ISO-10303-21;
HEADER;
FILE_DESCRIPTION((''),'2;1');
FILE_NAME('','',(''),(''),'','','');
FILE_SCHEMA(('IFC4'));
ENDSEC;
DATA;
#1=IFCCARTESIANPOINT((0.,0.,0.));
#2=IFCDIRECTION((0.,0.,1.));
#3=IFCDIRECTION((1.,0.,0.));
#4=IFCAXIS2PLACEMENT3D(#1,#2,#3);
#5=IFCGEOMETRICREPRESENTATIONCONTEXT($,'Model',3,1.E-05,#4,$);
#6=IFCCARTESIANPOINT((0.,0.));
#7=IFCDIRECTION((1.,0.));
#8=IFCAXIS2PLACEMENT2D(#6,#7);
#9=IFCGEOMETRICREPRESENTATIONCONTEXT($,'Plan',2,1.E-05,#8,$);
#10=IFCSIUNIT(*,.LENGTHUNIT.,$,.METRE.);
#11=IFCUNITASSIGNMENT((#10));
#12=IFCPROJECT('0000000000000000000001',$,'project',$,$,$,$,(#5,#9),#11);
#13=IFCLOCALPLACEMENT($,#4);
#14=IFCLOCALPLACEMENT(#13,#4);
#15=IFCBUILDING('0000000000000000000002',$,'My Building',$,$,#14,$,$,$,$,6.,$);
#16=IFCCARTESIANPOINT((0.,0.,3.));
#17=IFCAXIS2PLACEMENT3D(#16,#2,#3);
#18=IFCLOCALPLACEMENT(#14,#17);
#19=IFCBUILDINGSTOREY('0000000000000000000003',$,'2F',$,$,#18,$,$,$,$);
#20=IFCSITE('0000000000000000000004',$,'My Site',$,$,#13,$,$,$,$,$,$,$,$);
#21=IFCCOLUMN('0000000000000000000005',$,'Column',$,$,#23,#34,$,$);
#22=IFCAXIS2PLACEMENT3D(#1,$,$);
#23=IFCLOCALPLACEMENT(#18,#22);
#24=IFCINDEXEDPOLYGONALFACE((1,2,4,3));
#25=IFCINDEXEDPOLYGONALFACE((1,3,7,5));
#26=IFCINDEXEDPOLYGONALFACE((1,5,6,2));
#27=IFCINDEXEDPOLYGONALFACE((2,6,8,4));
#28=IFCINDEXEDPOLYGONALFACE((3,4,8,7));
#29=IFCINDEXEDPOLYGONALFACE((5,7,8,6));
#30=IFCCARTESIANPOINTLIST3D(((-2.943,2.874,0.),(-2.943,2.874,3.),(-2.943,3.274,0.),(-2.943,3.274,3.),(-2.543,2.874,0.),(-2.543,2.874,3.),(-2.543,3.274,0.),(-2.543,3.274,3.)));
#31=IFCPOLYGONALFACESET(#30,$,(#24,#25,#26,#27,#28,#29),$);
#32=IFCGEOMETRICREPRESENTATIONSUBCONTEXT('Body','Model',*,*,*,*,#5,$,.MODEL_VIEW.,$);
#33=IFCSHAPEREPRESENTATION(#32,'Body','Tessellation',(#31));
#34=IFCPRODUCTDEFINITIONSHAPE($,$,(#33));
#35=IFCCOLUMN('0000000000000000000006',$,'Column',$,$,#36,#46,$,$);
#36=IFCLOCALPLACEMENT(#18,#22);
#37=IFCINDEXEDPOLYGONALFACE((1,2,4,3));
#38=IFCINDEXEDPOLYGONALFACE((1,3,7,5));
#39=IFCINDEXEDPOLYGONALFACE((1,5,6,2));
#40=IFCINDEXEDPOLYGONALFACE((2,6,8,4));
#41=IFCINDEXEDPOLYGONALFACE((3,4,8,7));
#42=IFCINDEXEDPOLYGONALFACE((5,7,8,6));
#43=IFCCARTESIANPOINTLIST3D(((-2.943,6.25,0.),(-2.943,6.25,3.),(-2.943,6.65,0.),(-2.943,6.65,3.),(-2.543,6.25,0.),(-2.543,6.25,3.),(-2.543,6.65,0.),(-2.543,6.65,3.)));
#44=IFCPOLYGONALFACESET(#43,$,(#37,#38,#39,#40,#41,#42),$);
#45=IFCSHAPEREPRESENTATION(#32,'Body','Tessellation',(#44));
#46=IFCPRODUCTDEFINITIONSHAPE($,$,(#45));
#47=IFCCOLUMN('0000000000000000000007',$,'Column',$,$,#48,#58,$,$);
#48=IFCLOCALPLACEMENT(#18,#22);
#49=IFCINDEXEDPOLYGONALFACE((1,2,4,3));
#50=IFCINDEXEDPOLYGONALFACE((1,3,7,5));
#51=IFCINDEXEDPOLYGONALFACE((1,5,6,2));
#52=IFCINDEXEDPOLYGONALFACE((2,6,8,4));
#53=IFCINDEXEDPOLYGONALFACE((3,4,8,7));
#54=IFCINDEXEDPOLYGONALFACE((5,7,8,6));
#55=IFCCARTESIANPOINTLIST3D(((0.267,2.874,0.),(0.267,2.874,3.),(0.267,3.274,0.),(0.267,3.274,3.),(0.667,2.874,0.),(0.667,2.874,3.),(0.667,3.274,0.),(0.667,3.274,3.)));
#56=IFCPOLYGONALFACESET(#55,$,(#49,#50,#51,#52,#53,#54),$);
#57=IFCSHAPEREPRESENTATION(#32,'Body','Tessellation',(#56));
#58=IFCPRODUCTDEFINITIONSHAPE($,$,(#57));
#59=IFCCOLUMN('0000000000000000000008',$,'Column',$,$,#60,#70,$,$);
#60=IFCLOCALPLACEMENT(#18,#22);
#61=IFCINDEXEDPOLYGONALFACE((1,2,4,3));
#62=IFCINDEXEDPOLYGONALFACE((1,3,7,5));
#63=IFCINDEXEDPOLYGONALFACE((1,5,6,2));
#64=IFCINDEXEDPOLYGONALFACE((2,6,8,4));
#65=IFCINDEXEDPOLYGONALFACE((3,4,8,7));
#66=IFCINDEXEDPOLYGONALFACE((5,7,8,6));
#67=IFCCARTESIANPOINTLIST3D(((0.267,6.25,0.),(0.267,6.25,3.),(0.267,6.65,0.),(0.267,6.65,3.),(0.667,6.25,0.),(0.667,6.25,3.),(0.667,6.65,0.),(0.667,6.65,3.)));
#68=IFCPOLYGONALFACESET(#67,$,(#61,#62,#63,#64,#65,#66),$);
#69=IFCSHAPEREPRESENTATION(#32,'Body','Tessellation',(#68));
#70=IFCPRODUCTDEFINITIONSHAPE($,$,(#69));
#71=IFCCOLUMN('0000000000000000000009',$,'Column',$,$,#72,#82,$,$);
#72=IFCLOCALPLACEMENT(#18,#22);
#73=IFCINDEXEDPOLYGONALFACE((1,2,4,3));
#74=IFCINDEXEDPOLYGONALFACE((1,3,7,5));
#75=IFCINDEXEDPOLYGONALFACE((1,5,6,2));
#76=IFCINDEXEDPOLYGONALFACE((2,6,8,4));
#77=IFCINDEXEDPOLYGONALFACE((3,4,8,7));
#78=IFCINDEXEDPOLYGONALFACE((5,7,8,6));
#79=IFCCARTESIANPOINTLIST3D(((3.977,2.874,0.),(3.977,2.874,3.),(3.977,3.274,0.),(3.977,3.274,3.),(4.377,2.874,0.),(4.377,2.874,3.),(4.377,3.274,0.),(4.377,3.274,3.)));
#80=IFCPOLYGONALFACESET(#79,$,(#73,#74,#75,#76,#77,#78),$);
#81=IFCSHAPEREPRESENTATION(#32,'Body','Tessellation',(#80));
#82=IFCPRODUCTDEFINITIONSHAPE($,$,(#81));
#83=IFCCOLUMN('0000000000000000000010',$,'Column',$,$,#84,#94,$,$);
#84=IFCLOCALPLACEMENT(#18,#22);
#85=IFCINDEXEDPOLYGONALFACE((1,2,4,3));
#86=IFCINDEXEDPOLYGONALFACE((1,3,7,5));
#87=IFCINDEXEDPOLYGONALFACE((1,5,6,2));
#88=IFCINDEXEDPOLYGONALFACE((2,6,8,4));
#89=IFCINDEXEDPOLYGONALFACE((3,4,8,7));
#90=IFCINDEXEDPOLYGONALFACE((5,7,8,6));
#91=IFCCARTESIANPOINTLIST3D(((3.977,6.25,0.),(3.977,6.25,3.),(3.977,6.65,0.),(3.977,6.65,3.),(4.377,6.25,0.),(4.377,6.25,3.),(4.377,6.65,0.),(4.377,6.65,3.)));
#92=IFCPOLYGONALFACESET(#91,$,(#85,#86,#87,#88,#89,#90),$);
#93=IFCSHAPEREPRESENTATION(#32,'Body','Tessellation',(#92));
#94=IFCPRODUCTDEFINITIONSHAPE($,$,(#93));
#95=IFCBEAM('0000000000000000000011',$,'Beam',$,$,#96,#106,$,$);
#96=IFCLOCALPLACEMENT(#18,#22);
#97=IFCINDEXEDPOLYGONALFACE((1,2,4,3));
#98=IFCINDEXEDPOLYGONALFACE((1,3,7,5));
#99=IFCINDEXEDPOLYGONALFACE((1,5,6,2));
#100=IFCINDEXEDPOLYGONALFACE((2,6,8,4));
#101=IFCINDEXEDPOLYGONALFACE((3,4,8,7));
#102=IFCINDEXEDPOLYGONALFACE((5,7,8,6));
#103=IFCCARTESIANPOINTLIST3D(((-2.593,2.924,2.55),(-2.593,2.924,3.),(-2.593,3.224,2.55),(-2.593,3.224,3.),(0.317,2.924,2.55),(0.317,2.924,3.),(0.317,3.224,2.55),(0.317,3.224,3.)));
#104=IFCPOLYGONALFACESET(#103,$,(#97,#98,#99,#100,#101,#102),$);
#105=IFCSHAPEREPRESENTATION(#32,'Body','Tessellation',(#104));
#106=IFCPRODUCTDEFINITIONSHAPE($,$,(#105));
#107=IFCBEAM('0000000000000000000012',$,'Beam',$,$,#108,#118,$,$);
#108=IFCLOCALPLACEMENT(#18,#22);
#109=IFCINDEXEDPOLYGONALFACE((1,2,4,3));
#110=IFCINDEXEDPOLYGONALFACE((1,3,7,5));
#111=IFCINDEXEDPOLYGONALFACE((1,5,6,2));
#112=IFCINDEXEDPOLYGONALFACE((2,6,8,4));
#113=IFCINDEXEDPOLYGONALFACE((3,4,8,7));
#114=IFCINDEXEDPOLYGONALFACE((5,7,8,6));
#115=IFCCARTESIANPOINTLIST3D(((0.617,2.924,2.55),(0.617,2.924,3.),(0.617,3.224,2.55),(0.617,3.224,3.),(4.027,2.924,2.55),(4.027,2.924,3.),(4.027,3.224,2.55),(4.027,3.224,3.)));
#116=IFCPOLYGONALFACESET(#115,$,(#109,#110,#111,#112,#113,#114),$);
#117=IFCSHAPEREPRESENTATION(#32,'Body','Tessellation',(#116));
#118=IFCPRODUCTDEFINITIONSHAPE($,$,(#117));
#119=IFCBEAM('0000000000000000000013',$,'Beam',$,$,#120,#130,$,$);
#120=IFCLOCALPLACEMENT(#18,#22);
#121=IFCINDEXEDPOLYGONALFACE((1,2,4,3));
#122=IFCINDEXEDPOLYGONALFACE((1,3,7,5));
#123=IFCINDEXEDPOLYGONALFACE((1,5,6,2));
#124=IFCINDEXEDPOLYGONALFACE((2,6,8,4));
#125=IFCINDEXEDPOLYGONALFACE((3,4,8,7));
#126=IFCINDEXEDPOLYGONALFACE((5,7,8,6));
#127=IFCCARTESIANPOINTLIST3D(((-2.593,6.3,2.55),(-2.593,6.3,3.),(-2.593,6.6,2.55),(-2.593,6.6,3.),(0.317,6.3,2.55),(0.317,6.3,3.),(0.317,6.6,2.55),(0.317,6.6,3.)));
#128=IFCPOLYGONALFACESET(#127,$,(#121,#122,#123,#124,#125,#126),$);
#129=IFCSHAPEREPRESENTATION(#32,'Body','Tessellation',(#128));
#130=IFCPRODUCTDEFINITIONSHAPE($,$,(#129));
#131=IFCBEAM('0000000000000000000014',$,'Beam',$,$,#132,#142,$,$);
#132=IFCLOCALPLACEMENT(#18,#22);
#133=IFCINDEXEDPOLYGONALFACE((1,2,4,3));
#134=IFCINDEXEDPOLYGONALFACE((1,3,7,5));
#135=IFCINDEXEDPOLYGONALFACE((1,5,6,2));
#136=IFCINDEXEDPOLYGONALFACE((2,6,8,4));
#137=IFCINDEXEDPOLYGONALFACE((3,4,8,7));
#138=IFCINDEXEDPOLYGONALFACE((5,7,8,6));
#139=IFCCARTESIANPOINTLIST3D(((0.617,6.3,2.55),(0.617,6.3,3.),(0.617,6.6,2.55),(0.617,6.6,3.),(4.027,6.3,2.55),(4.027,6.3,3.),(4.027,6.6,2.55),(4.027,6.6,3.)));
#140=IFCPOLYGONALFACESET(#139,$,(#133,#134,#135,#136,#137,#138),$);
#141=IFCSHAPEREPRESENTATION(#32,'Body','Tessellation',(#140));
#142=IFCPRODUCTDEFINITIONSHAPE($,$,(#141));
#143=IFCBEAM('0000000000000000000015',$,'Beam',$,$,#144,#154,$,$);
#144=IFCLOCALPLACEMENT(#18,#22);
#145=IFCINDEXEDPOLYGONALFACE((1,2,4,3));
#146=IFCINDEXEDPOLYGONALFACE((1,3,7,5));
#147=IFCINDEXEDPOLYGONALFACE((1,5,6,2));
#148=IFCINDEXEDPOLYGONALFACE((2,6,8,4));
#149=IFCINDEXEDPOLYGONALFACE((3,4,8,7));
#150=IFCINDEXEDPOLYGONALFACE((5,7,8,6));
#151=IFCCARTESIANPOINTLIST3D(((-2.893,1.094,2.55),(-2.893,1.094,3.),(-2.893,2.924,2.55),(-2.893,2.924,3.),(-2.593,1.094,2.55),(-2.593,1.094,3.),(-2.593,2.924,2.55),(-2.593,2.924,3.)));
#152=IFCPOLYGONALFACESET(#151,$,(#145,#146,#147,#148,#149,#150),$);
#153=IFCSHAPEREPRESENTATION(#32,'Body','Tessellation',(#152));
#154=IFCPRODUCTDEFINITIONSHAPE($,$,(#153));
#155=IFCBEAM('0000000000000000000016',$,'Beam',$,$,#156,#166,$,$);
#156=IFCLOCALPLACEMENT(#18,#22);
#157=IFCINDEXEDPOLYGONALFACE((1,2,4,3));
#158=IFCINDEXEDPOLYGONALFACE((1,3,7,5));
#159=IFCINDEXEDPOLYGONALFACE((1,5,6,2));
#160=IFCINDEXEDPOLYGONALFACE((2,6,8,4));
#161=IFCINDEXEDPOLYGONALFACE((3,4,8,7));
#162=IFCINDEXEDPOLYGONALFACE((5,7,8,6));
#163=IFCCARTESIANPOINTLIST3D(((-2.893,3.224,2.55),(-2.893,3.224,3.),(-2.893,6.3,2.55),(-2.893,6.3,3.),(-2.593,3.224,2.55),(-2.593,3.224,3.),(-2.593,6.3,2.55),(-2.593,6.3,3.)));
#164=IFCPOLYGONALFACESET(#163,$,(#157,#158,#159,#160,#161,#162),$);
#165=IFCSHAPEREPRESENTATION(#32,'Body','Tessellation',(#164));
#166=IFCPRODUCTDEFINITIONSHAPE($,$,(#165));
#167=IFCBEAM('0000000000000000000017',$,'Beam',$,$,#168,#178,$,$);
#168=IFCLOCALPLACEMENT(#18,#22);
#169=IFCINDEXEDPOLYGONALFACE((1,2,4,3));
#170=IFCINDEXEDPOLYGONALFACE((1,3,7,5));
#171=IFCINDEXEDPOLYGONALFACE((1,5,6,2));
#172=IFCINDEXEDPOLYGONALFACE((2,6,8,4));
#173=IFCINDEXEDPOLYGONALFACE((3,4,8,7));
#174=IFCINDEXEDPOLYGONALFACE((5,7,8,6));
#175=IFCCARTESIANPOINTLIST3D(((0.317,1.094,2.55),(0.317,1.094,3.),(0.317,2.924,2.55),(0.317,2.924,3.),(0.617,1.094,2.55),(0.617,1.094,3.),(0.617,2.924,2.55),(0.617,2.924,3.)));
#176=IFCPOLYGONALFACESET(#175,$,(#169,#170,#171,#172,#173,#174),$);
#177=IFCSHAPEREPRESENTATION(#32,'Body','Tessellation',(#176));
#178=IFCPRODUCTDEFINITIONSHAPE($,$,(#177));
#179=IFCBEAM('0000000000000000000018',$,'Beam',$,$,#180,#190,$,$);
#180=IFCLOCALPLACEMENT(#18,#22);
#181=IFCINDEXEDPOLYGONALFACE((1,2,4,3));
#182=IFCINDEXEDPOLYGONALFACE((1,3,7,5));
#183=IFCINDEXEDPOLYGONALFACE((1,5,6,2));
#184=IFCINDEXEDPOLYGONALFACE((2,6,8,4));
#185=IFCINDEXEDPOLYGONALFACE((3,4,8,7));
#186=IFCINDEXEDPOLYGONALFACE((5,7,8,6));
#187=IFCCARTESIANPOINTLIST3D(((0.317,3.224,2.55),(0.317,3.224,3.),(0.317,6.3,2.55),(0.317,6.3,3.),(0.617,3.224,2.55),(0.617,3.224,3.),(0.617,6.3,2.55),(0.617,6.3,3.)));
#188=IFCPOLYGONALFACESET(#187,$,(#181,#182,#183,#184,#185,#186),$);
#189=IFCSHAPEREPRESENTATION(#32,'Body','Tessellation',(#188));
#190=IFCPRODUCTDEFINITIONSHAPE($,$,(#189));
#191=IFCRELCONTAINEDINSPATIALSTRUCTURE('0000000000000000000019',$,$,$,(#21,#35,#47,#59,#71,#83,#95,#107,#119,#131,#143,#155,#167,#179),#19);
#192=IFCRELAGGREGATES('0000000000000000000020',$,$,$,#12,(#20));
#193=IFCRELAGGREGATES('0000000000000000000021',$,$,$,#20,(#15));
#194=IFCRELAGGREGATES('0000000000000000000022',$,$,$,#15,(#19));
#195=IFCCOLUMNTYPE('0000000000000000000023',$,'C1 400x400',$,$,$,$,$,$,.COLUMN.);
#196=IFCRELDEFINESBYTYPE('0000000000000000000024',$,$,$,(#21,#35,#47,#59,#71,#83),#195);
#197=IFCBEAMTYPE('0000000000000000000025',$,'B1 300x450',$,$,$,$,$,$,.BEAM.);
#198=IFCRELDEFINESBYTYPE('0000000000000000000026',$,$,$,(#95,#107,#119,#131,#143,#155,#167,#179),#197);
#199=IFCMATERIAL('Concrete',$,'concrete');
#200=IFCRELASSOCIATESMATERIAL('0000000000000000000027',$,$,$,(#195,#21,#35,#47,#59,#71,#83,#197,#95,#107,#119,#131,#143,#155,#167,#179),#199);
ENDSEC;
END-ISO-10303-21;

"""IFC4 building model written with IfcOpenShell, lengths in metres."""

from ifc_helpers import new_model, si_unit, frame, origin_with_axes, origin_2d_with_axis, place, context, subcontext, project, spatial, rectangle, extrude, material, material_profile, profile_set, profile_usage, type_object, element, save


model = new_model("IFC4")

# Units and contexts
model_context = context("Model", 3, precision=1e-05, world=origin_with_axes())
plan_context = context("Plan", 2, precision=1e-05, world=origin_2d_with_axis())
body_context_1 = subcontext(model_context, "Body", "Model", "MODEL_VIEW")
ifc_project = project(units=[si_unit("LENGTHUNIT", "METRE")], contexts=[model_context, plan_context])

# Site, building, storey
site_placement = place(None, origin_with_axes())
site = spatial("IfcSite", under=ifc_project, at=site_placement, Name="My Site")
building_placement = place(site_placement, origin_with_axes())
building = spatial("IfcBuilding", under=site, at=building_placement, Name="My Building", ElevationOfTerrain=6.0)
storey_placement = place(building_placement, frame((0.0, 0.0, 3.0), z_axis=(0.0, 0.0, 1.0), x_axis=(1.0, 0.0, 0.0)))
storey = spatial("IfcBuildingStorey", under=building, at=storey_placement, Name="2F")

# Columns
ifc_material_1 = material(Name="Concrete", Category="concrete")
ifc_material_profile_1 = material_profile(ifc_material_1, rectangle(XDim=0.4, YDim=0.4))
ifc_profile_set_1 = profile_set([ifc_material_profile_1], Name="C1 400x400")
ifc_profile_usage_1 = profile_usage(ifc_profile_set_1, cardinal=5)
column_type = type_object("IfcColumnType", Name="C1 400x400", PredefinedType="COLUMN", material=ifc_profile_set_1)
column_1_placement = place(storey_placement, frame((-2.743, 3.074, 0.0), z_axis=(0.0, 0.0, 1.0), x_axis=(1.0, 0.0, 0.0)))
element("IfcColumn", 1, at=column_1_placement, inside=storey, type_object=column_type, material=ifc_profile_usage_1, Name="Column", context=body_context_1, shape_type="SweptSolid", body=[
    extrude(rectangle(XDim=0.4, YDim=0.4), origin_with_axes(), (0.0, 0.0, 1.0), 3.0),
])
ifc_profile_usage_2 = profile_usage(ifc_profile_set_1, cardinal=5)
column_2_placement = place(storey_placement, frame((-2.743, 6.45, 0.0), z_axis=(0.0, 0.0, 1.0), x_axis=(1.0, 0.0, 0.0)))
element("IfcColumn", 2, at=column_2_placement, inside=storey, type_object=column_type, material=ifc_profile_usage_2, Name="Column", context=body_context_1, shape_type="SweptSolid", body=[
    extrude(rectangle(XDim=0.4, YDim=0.4), origin_with_axes(), (0.0, 0.0, 1.0), 3.0),
])
ifc_profile_usage_3 = profile_usage(ifc_profile_set_1, cardinal=5)
column_3_placement = place(storey_placement, frame((0.467, 3.074, 0.0), z_axis=(0.0, 0.0, 1.0), x_axis=(1.0, 0.0, 0.0)))
element("IfcColumn", 3, at=column_3_placement, inside=storey, type_object=column_type, material=ifc_profile_usage_3, Name="Column", context=body_context_1, shape_type="SweptSolid", body=[
    extrude(rectangle(XDim=0.4, YDim=0.4), origin_with_axes(), (0.0, 0.0, 1.0), 3.0),
])
ifc_profile_usage_4 = profile_usage(ifc_profile_set_1, cardinal=5)
column_4_placement = place(storey_placement, frame((0.467, 6.45, 0.0), z_axis=(0.0, 0.0, 1.0), x_axis=(1.0, 0.0, 0.0)))
element("IfcColumn", 4, at=column_4_placement, inside=storey, type_object=column_type, material=ifc_profile_usage_4, Name="Column", context=body_context_1, shape_type="SweptSolid", body=[
    extrude(rectangle(XDim=0.4, YDim=0.4), origin_with_axes(), (0.0, 0.0, 1.0), 3.0),
])
ifc_profile_usage_5 = profile_usage(ifc_profile_set_1, cardinal=5)
column_5_placement = place(storey_placement, frame((4.177, 3.074, 0.0), z_axis=(0.0, 0.0, 1.0), x_axis=(1.0, 0.0, 0.0)))
element("IfcColumn", 5, at=column_5_placement, inside=storey, type_object=column_type, material=ifc_profile_usage_5, Name="Column", context=body_context_1, shape_type="SweptSolid", body=[
    extrude(rectangle(XDim=0.4, YDim=0.4), origin_with_axes(), (0.0, 0.0, 1.0), 3.0),
])
ifc_profile_usage_6 = profile_usage(ifc_profile_set_1, cardinal=5)
column_6_placement = place(storey_placement, frame((4.177, 6.45, 0.0), z_axis=(0.0, 0.0, 1.0), x_axis=(1.0, 0.0, 0.0)))
element("IfcColumn", 6, at=column_6_placement, inside=storey, type_object=column_type, material=ifc_profile_usage_6, Name="Column", context=body_context_1, shape_type="SweptSolid", body=[
    extrude(rectangle(XDim=0.4, YDim=0.4), origin_with_axes(), (0.0, 0.0, 1.0), 3.0),
])

# Beams
ifc_material_profile_2 = material_profile(ifc_material_1, rectangle(XDim=0.3, YDim=0.45))
ifc_profile_set_2 = profile_set([ifc_material_profile_2], Name="B1 300x450")
ifc_profile_usage_7 = profile_usage(ifc_profile_set_2, cardinal=8)
beam_type = type_object("IfcBeamType", Name="B1 300x450", PredefinedType="BEAM", material=ifc_profile_set_2)
beam_1_placement = place(storey_placement, frame((-2.593, 3.074, 2.975), z_axis=(1.0, 0.0, 0.0), x_axis=(0.0, 1.0, 0.0)))
element("IfcBeam", 7, at=beam_1_placement, inside=storey, type_object=beam_type, material=ifc_profile_usage_7, Name="Beam", context=body_context_1, shape_type="SweptSolid", body=[
    extrude(rectangle(XDim=0.3, YDim=0.45), frame((0.0, -0.2, 0.0), z_axis=(0.0, 0.0, 1.0), x_axis=(1.0, 0.0, 0.0)), (0.0, 0.0, 1.0), 2.91),
])
ifc_profile_usage_8 = profile_usage(ifc_profile_set_2, cardinal=8)
beam_2_placement = place(storey_placement, frame((0.617, 3.074, 2.975), z_axis=(1.0, 0.0, 0.0), x_axis=(0.0, 1.0, 0.0)))
element("IfcBeam", 8, at=beam_2_placement, inside=storey, type_object=beam_type, material=ifc_profile_usage_8, Name="Beam", context=body_context_1, shape_type="SweptSolid", body=[
    extrude(rectangle(XDim=0.3, YDim=0.45), frame((0.0, -0.2, 0.0), z_axis=(0.0, 0.0, 1.0), x_axis=(1.0, 0.0, 0.0)), (0.0, 0.0, 1.0), 3.41),
])
ifc_profile_usage_9 = profile_usage(ifc_profile_set_2, cardinal=8)
beam_3_placement = place(storey_placement, frame((-2.593, 6.45, 2.975), z_axis=(1.0, 0.0, 0.0), x_axis=(0.0, 1.0, 0.0)))
element("IfcBeam", 9, at=beam_3_placement, inside=storey, type_object=beam_type, material=ifc_profile_usage_9, Name="Beam", context=body_context_1, shape_type="SweptSolid", body=[
    extrude(rectangle(XDim=0.3, YDim=0.45), frame((0.0, -0.2, 0.0), z_axis=(0.0, 0.0, 1.0), x_axis=(1.0, 0.0, 0.0)), (0.0, 0.0, 1.0), 2.91),
])
ifc_profile_usage_10 = profile_usage(ifc_profile_set_2, cardinal=8)
beam_4_placement = place(storey_placement, frame((0.617, 6.45, 2.975), z_axis=(1.0, 0.0, 0.0), x_axis=(0.0, 1.0, 0.0)))
element("IfcBeam", 10, at=beam_4_placement, inside=storey, type_object=beam_type, material=ifc_profile_usage_10, Name="Beam", context=body_context_1, shape_type="SweptSolid", body=[
    extrude(rectangle(XDim=0.3, YDim=0.45), frame((0.0, -0.2, 0.0), z_axis=(0.0, 0.0, 1.0), x_axis=(1.0, 0.0, 0.0)), (0.0, 0.0, 1.0), 3.41),
])
ifc_profile_usage_11 = profile_usage(ifc_profile_set_2, cardinal=8)
beam_5_placement = place(storey_placement, frame((-2.743, 1.094, 2.975), z_axis=(0.0, 1.0, 0.0), x_axis=(-1.0, 0.0, 0.0)))
element("IfcBeam", 11, at=beam_5_placement, inside=storey, type_object=beam_type, material=ifc_profile_usage_11, Name="Beam", context=body_context_1, shape_type="SweptSolid", body=[
    extrude(rectangle(XDim=0.3, YDim=0.45), frame((0.0, -0.2, 0.0), z_axis=(0.0, 0.0, 1.0), x_axis=(1.0, 0.0, 0.0)), (0.0, 0.0, 1.0), 1.83),
])
ifc_profile_usage_12 = profile_usage(ifc_profile_set_2, cardinal=8)
beam_6_placement = place(storey_placement, frame((-2.743, 3.224, 2.975), z_axis=(0.0, 1.0, 0.0), x_axis=(-1.0, 0.0, 0.0)))
element("IfcBeam", 12, at=beam_6_placement, inside=storey, type_object=beam_type, material=ifc_profile_usage_12, Name="Beam", context=body_context_1, shape_type="SweptSolid", body=[
    extrude(rectangle(XDim=0.3, YDim=0.45), frame((0.0, -0.2, 0.0), z_axis=(0.0, 0.0, 1.0), x_axis=(1.0, 0.0, 0.0)), (0.0, 0.0, 1.0), 3.076),
])
ifc_profile_usage_13 = profile_usage(ifc_profile_set_2, cardinal=8)
beam_7_placement = place(storey_placement, frame((0.467, 1.094, 2.975), z_axis=(0.0, 1.0, 0.0), x_axis=(-1.0, 0.0, 0.0)))
element("IfcBeam", 13, at=beam_7_placement, inside=storey, type_object=beam_type, material=ifc_profile_usage_13, Name="Beam", context=body_context_1, shape_type="SweptSolid", body=[
    extrude(rectangle(XDim=0.3, YDim=0.45), frame((0.0, -0.2, 0.0), z_axis=(0.0, 0.0, 1.0), x_axis=(1.0, 0.0, 0.0)), (0.0, 0.0, 1.0), 1.83),
])
ifc_profile_usage_14 = profile_usage(ifc_profile_set_2, cardinal=8)
beam_8_placement = place(storey_placement, frame((0.467, 3.224, 2.975), z_axis=(0.0, 1.0, 0.0), x_axis=(-1.0, 0.0, 0.0)))
element("IfcBeam", 14, at=beam_8_placement, inside=storey, type_object=beam_type, material=ifc_profile_usage_14, Name="Beam", context=body_context_1, shape_type="SweptSolid", body=[
    extrude(rectangle(XDim=0.3, YDim=0.45), frame((0.0, -0.2, 0.0), z_axis=(0.0, 0.0, 1.0), x_axis=(1.0, 0.0, 0.0)), (0.0, 0.0, 1.0), 3.076),
])

save(model, "model.ifc")
